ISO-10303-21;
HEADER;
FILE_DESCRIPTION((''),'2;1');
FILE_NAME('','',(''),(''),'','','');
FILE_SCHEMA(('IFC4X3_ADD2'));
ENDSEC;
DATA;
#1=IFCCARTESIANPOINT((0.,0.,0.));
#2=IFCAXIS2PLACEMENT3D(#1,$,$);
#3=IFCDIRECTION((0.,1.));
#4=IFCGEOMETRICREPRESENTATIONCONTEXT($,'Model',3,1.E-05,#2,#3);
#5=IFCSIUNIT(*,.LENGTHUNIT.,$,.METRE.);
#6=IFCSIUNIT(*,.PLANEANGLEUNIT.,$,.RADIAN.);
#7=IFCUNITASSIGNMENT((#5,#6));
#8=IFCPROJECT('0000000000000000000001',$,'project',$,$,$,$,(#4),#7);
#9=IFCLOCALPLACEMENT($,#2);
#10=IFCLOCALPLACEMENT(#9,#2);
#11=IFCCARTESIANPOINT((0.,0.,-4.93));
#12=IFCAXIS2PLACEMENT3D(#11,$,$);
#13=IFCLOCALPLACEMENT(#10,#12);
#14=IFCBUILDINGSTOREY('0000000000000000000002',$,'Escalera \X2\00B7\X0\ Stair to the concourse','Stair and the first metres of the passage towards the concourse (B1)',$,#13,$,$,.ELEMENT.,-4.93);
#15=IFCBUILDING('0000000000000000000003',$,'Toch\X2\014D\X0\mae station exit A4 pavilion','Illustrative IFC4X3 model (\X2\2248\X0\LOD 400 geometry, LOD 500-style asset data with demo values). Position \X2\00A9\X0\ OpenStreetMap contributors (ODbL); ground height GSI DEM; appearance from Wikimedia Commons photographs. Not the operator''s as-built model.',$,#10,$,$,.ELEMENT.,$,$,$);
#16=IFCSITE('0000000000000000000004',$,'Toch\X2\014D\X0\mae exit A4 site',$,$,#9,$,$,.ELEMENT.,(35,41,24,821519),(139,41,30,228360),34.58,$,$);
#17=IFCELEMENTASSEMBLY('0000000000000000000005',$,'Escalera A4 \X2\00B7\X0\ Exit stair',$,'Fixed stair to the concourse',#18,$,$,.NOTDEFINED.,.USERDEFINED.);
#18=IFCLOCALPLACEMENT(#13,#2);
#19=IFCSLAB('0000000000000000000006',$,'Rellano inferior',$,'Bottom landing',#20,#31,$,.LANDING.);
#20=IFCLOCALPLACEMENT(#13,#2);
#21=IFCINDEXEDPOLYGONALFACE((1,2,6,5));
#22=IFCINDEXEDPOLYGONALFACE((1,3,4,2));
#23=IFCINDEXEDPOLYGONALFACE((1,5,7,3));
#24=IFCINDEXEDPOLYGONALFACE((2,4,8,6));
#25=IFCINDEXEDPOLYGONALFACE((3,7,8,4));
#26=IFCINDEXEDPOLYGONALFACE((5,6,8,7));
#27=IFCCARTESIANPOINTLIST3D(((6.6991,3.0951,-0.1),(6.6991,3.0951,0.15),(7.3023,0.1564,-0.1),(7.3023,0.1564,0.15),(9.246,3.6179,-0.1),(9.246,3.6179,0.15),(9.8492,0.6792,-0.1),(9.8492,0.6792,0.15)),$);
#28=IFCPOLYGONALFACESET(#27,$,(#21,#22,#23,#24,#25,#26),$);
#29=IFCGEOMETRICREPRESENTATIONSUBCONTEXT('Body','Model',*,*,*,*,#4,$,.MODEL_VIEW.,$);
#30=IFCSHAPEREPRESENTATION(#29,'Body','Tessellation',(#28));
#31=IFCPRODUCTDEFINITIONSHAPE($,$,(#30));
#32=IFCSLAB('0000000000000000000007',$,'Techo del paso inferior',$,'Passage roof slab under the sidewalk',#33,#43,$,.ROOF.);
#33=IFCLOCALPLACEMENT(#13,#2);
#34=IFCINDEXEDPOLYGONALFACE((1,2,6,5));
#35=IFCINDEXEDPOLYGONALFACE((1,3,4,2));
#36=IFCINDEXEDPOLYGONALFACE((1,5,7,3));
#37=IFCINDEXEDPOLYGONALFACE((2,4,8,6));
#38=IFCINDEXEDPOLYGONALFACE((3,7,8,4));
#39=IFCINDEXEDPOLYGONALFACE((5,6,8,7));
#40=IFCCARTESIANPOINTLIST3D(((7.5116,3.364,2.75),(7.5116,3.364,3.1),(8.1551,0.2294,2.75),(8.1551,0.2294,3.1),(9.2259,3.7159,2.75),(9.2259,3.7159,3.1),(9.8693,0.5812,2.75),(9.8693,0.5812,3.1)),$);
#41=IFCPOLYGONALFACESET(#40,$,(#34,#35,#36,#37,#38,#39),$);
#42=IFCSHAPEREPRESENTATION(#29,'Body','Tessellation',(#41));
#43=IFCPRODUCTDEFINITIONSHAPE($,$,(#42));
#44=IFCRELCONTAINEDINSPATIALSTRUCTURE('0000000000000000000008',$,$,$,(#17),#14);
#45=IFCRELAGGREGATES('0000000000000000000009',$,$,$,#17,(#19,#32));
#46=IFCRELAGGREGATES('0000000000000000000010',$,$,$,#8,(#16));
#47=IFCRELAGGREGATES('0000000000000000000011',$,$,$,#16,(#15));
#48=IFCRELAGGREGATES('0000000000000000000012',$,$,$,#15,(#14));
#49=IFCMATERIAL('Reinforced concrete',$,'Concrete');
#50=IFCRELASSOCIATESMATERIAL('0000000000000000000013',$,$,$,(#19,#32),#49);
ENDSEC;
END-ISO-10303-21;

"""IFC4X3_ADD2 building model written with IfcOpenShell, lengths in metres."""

from ifc_helpers import new_model, si_unit, direction, frame, frame_2d, origin, place, context, subcontext, project, spatial, rectangle, extrude, material, element, aggregate, save


model = new_model("IFC4X3_ADD2")

# Units and contexts
model_context = context("Model", 3, precision=1e-05, world=origin(), true_north=direction((0.0, 1.0)))
body_context = subcontext(model_context, "Body", "Model", "MODEL_VIEW")
ifc_project = project(units=[si_unit("LENGTHUNIT", "METRE"), si_unit("PLANEANGLEUNIT", "RADIAN")], contexts=[model_context])

# Site, building, storey
site_placement = place(None, origin())
site = spatial("IfcSite", under=ifc_project, at=site_placement, Name="Tochōmae exit A4 site", CompositionType="ELEMENT", RefLatitude=(35, 41, 24, 821519), RefLongitude=(139, 41, 30, 228360), RefElevation=34.58)
building_placement = place(site_placement, origin())
building = spatial("IfcBuilding", under=site, at=building_placement, Name="Tochōmae station exit A4 pavilion", Description="Illustrative IFC4X3 model (≈LOD 400 geometry, LOD 500-style asset data with demo values). Position © OpenStreetMap contributors (ODbL); ground height GSI DEM; appearance from Wikimedia Commons photographs. Not the operator's as-built model.", CompositionType="ELEMENT")
storey_placement = place(building_placement, frame((0.0, 0.0, -4.93)))
storey = spatial("IfcBuildingStorey", under=building, at=storey_placement, Name="Escalera · Stair to the concourse", Description="Stair and the first metres of the passage towards the concourse (B1)", CompositionType="ELEMENT", Elevation=-4.93)

# Element assembly, slabs
assembly_placement = place(building_placement, origin())
assembly = element("IfcElementAssembly", 1, at=assembly_placement, inside=storey, Name="Escalera A4 · Exit stair", ObjectType="Fixed stair to the concourse", AssemblyPlace="NOTDEFINED", PredefinedType="USERDEFINED")
ifc_material_1 = material(Name="Reinforced concrete", Category="Concrete")
slab_1_placement = place(building_placement, origin())
slab_1 = element("IfcSlab", 2, at=slab_1_placement, material=ifc_material_1, Name="Rellano inferior", ObjectType="Bottom landing", PredefinedType="LANDING", context=body_context, shape_type="SweptSolid", body=[
    extrude(rectangle(XDim=2.6, YDim=3.0, at=frame_2d((0.0, 0.0), x_axis=(0.979575, 0.201078))), frame((8.2742, 1.8872, -5.03)), (0.0, 0.0, 1.0), 0.25),
])
slab_2_placement = place(building_placement, origin())
slab_2 = element("IfcSlab", 3, at=slab_2_placement, material=ifc_material_1, Name="Techo del paso inferior", ObjectType="Passage roof slab under the sidewalk", PredefinedType="ROOF", context=body_context, shape_type="SweptSolid", body=[
    extrude(rectangle(XDim=1.75, YDim=3.2, at=frame_2d((0.0, 0.0), x_axis=(0.979575, 0.201078))), frame((8.6905, 1.9726, -2.18)), (0.0, 0.0, 1.0), 0.35),
])
aggregate(assembly, [slab_1, slab_2])

save(model, "model.ifc")
